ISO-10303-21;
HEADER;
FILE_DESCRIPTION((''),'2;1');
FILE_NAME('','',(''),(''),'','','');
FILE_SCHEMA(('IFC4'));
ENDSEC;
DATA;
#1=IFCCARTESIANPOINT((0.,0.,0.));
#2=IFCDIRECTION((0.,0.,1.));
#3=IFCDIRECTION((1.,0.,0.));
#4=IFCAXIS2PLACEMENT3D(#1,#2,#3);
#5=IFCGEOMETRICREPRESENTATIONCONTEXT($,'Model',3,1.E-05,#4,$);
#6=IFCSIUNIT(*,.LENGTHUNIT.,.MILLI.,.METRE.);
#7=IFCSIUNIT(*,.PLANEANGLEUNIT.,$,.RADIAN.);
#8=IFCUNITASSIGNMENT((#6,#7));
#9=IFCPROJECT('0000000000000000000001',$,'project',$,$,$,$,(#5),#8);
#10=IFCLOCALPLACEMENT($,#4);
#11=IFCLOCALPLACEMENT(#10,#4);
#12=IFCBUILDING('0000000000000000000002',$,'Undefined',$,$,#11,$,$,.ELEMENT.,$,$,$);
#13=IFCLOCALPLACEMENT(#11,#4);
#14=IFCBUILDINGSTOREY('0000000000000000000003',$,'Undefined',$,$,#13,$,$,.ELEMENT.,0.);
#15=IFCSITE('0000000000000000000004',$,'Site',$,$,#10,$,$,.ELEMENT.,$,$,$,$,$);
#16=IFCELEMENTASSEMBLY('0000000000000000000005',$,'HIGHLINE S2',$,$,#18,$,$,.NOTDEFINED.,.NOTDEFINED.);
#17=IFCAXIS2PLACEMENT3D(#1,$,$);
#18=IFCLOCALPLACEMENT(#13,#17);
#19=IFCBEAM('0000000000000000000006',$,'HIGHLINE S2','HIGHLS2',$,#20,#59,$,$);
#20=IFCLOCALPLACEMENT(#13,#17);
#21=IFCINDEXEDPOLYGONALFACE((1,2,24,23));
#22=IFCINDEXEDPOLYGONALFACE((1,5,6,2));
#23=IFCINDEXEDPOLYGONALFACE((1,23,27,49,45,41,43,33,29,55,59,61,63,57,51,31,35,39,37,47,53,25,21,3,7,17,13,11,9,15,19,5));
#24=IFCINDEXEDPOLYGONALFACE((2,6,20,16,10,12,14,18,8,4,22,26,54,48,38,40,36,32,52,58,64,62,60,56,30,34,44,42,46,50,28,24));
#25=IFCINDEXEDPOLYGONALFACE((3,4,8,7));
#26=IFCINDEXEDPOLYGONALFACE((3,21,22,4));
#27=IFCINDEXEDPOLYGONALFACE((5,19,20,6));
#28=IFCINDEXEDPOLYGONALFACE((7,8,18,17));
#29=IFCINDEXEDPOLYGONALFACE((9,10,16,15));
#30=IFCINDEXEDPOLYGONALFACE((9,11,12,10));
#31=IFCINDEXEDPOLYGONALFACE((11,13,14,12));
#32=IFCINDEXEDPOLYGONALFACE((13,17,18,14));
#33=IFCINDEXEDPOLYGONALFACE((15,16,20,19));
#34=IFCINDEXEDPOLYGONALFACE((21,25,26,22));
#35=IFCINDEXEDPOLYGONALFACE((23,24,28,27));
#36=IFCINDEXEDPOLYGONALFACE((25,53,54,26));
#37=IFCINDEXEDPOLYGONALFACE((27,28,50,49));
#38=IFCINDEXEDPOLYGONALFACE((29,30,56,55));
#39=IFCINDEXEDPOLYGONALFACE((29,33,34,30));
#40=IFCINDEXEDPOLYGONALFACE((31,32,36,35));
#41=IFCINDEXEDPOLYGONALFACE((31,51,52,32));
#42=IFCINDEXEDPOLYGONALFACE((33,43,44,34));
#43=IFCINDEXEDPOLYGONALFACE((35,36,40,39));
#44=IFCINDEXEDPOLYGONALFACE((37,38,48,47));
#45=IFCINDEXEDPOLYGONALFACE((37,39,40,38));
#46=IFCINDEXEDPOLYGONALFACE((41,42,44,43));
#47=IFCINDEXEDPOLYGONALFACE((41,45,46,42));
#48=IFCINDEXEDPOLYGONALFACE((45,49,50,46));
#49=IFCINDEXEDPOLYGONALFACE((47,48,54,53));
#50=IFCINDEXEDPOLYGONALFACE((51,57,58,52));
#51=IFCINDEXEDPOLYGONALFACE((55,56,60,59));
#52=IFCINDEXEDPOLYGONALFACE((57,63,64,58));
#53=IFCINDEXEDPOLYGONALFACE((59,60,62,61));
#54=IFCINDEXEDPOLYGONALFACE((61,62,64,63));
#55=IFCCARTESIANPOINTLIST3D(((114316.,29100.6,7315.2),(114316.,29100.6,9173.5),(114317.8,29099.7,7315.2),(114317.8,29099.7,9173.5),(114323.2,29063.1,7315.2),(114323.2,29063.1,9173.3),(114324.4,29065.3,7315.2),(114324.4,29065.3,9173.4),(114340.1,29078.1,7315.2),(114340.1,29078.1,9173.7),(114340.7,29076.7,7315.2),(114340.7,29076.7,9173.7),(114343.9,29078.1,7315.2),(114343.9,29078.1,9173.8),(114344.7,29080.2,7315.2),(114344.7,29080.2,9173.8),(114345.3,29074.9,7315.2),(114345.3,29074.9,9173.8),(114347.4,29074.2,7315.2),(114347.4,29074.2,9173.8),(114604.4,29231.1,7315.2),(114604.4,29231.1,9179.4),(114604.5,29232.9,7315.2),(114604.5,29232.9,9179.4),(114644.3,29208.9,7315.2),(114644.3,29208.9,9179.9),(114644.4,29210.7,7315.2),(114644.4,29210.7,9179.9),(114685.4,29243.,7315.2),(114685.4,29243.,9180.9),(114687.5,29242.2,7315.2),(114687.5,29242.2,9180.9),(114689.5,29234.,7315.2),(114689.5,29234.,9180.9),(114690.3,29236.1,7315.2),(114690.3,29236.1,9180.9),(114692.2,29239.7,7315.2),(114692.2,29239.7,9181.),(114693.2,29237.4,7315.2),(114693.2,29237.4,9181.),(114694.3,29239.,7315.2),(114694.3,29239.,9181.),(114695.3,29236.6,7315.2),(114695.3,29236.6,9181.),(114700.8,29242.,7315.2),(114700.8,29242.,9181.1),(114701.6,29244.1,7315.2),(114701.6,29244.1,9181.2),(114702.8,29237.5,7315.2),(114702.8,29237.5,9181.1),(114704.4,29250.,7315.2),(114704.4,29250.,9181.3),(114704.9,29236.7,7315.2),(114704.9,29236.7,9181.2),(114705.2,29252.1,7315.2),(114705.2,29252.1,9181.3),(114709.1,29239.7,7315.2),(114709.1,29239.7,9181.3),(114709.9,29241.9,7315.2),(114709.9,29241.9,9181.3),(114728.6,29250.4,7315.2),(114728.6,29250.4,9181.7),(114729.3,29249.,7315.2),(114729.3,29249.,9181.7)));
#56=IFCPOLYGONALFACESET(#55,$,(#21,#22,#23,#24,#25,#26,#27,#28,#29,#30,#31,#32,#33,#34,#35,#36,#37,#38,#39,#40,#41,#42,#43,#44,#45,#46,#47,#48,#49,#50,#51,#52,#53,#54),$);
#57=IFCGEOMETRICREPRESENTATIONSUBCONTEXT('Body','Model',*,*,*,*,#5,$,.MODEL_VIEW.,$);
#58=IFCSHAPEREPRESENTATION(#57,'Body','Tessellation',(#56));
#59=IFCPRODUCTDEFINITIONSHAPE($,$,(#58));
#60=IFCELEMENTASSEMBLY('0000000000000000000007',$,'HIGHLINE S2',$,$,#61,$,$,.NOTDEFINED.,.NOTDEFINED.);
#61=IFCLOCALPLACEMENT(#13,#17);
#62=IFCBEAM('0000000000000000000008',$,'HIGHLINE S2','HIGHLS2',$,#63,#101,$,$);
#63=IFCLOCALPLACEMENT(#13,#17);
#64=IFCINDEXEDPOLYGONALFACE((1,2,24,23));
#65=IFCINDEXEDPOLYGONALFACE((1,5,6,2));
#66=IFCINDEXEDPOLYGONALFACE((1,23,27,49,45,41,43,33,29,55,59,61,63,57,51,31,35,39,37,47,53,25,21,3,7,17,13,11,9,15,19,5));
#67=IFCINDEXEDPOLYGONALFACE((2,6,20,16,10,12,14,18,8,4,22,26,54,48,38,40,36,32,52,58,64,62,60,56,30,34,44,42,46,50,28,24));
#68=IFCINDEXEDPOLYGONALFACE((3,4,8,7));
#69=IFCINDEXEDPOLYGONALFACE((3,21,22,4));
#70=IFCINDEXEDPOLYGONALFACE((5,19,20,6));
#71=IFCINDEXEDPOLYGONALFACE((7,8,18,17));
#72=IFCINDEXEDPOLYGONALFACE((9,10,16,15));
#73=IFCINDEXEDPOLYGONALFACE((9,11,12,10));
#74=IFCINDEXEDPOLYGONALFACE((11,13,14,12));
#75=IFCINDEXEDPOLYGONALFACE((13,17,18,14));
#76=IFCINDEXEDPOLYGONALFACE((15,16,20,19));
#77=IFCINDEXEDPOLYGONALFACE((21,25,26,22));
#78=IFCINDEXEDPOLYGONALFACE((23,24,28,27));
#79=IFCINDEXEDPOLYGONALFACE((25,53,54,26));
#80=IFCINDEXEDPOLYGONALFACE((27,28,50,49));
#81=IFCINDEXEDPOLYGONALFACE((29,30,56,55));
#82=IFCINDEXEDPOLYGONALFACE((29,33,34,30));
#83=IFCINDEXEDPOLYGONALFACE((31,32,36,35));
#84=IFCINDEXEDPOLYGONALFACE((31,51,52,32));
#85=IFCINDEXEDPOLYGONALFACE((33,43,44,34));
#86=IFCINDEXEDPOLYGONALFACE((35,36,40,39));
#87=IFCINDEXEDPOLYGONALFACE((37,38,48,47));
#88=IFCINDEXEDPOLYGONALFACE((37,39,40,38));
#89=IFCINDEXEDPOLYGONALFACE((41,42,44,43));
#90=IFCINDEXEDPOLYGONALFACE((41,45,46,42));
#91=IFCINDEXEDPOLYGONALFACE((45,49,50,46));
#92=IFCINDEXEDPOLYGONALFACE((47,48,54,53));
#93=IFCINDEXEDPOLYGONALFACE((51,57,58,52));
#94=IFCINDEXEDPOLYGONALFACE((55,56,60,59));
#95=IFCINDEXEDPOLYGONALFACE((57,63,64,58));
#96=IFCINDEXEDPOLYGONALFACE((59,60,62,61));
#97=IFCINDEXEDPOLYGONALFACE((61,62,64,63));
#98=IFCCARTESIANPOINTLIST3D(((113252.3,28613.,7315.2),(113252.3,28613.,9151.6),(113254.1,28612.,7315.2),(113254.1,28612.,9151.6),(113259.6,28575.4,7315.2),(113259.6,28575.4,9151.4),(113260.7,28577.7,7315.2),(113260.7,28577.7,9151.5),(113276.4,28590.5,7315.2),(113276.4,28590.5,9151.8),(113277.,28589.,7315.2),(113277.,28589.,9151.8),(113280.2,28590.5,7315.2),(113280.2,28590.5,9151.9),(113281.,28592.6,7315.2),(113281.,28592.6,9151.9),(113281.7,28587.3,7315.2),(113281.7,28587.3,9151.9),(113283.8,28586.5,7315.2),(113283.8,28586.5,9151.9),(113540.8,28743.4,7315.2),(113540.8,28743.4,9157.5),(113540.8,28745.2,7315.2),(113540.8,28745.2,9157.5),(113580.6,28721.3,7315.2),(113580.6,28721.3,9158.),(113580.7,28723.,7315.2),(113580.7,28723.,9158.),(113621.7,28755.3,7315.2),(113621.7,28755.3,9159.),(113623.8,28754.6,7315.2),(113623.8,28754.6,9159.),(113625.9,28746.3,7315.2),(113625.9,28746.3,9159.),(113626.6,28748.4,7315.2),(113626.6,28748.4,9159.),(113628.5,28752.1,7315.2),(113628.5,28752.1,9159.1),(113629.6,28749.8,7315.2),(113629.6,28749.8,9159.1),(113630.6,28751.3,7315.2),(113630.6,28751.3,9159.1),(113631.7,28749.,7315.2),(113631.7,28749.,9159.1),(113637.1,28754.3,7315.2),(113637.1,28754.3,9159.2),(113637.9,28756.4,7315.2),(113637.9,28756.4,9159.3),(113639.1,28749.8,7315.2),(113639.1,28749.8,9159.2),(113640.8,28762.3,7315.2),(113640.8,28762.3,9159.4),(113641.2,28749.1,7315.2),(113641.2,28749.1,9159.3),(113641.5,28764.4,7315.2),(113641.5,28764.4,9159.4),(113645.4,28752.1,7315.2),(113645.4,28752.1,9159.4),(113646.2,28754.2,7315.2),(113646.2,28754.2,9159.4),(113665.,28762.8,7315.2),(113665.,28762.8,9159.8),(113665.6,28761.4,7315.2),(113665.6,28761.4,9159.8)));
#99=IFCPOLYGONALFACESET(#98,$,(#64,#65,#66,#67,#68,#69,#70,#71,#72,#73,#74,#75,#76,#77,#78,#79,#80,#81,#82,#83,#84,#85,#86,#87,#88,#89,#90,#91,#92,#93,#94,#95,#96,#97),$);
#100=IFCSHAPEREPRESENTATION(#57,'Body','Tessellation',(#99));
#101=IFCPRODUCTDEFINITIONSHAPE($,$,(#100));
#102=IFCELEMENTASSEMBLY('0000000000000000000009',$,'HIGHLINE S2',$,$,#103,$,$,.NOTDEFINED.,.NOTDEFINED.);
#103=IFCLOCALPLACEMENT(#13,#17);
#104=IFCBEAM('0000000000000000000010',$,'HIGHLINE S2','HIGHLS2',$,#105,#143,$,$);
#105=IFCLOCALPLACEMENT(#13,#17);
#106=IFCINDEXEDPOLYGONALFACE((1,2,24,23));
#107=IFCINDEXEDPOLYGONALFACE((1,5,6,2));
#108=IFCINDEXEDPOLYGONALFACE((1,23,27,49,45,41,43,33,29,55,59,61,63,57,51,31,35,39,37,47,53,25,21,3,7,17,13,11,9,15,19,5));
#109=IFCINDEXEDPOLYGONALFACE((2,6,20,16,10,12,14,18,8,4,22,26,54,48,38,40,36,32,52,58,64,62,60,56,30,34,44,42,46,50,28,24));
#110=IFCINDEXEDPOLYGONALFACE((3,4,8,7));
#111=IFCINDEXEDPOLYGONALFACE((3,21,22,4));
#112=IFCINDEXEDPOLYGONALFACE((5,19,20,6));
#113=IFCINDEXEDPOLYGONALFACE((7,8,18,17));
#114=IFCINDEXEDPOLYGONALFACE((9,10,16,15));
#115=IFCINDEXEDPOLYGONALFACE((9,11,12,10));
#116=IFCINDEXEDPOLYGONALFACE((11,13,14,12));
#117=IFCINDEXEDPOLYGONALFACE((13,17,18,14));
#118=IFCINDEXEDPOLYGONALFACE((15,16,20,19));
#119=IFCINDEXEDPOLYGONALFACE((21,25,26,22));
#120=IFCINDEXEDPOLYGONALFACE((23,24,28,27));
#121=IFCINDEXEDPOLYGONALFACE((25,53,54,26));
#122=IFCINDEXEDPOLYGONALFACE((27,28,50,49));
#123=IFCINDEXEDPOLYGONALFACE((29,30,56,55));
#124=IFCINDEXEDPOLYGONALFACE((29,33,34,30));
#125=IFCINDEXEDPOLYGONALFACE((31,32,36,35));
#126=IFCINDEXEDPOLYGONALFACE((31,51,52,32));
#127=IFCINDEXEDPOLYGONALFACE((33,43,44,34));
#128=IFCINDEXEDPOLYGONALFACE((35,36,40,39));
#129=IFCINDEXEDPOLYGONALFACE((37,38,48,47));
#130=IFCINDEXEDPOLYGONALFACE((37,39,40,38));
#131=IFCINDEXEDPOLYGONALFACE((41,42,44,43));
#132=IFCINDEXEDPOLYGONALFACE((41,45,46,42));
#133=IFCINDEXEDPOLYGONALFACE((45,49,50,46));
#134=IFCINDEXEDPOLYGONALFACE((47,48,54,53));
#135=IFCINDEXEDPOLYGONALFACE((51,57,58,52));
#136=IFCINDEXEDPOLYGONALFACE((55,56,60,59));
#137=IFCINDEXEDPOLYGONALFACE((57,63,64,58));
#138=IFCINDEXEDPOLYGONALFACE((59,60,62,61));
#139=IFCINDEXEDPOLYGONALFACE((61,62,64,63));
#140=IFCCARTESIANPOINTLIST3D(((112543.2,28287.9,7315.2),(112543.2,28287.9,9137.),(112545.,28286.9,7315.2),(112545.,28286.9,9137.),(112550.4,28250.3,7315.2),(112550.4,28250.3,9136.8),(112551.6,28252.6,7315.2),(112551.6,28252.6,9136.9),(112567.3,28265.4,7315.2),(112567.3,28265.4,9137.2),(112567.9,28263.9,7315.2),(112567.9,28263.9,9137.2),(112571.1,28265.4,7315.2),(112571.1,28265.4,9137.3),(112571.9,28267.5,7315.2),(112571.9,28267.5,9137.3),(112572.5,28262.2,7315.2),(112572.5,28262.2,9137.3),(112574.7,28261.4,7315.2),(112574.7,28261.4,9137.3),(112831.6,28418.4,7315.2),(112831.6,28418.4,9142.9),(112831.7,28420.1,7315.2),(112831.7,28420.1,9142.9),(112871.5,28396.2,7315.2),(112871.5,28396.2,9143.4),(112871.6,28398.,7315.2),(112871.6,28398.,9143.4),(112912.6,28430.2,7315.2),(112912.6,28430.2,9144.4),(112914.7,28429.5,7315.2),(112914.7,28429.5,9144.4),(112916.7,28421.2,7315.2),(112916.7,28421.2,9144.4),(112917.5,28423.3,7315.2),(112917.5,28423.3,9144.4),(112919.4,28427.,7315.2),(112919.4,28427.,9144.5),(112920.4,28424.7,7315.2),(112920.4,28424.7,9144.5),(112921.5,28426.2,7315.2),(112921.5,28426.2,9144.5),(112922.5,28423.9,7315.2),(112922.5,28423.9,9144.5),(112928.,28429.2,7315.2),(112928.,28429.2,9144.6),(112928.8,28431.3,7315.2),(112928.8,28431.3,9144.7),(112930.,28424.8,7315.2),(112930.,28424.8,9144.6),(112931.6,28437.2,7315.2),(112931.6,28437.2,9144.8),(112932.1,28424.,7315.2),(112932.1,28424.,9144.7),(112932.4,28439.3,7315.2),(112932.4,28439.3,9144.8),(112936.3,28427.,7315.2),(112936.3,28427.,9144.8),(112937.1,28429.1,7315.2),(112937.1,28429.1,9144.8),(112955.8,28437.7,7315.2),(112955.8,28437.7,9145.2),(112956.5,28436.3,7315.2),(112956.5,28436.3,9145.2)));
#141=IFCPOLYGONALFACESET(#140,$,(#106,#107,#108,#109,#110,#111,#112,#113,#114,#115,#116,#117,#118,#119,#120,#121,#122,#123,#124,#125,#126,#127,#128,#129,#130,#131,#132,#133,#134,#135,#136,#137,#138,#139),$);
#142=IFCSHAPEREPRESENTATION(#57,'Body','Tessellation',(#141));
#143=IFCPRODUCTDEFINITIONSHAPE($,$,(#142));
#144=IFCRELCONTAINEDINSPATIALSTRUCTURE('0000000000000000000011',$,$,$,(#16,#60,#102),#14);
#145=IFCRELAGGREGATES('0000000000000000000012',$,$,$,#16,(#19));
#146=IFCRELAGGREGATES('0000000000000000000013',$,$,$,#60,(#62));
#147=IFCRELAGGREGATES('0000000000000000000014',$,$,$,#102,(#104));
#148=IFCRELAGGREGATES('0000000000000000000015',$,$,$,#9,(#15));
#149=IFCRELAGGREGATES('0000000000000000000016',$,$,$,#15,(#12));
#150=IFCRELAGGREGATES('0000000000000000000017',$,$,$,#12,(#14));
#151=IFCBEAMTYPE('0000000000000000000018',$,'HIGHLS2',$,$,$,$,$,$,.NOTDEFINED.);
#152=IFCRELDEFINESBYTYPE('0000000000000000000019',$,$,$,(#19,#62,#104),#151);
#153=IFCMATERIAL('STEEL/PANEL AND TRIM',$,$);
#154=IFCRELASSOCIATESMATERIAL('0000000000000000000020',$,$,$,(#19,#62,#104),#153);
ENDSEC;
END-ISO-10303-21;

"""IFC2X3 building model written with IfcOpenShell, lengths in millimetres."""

from ifc_helpers import new_model, si_unit, frame, origin_with_axes, place, context, subcontext, project, spatial, polyline, outline, extrude, boolean, halfspace, material, type_object, element, aggregate, save


model = new_model("IFC2X3")

# Units and contexts
model_context = context("Model", 3, precision=1e-05, world=origin_with_axes())
body_context = subcontext(model_context, "Body", "Model", "MODEL_VIEW")
ifc_project = project(units=[si_unit("LENGTHUNIT", "METRE", prefix="MILLI"), si_unit("PLANEANGLEUNIT", "RADIAN")], contexts=[model_context])

# Site, building, storey
site_placement = place(None, origin_with_axes())
site = spatial("IfcSite", under=ifc_project, at=site_placement, Name="Site", CompositionType="ELEMENT")
building_placement = place(site_placement, origin_with_axes())
building = spatial("IfcBuilding", under=site, at=building_placement, Name="Undefined", CompositionType="ELEMENT")
storey_placement = place(building_placement, origin_with_axes())
storey = spatial("IfcBuildingStorey", under=building, at=storey_placement, Name="Undefined", CompositionType="ELEMENT", Elevation=0.0)

# Element assemblies, beams
ifc_material_1 = material(Name="STEEL/PANEL AND TRIM")
beam_type_1 = type_object("IfcBeamType", Name="HIGHLS2", PredefinedType="NOTDEFINED")
assembly_1_placement = place(storey_placement, origin_with_axes())
assembly_1 = element("IfcElementAssembly", 1, at=assembly_1_placement, inside=storey, Name="HIGHLINE S2", AssemblyPlace="NOTDEFINED", PredefinedType="NOTDEFINED")
beam_1_placement = place(assembly_1_placement, frame((114316.0, 29100.6, 4267.2), z_axis=(0.41674, -0.909026, 0.0), x_axis=(0.0, 0.0, 1.0)))
beam_1 = element("IfcBeam", 2, at=beam_1_placement, type_object=beam_type_1, material=ifc_material_1, Name="HIGHLINE S2", Description="HIGHLS2", context=body_context, shape_type="CSG", body=[
    boolean("DIFFERENCE", boolean("DIFFERENCE", extrude(outline(polyline([(415.4, 26.1), (415.4, 37.3), (437.6, 37.3), (437.6, 35.7), (417.0, 35.7), (417.0, 24.5), (395.1, 24.5), (395.1, 34.4), (401.5, 34.4), (401.5, 31.9), (408.7, 31.9), (408.7, 36.8), (344.4, 36.8), (317.4, 0.0), (0.0, 0.0), (-9.0, 37.1), (17.6, 37.1), (17.6, 30.5), (12.5, 30.5), (12.5, 32.1), (16.0, 32.1), (16.0, 35.5), (-7.0, 35.5), (1.2, 1.6), (316.6, 1.6), (343.6, 38.4), (410.3, 38.4), (410.3, 30.3), (400.0, 30.3), (400.0, 32.8), (396.7, 32.8), (396.7, 26.1), (415.4, 26.1)])), frame((10000.0, 0.0, 0.0), z_axis=(-1.0, 0.0, 0.0), x_axis=(0.0, -1.0, 0.0)), (0.0, 0.0, 1.0), 10000.0), extrude(outline(polyline([(0.0, 0.0), (6400.8, 0.0), (6400.8, 3048.0), (0.0, 3048.0), (0.0, 0.0)])), frame((0.0, 3436.4, -9.8), z_axis=(0.0, 0.0, 1.0), x_axis=(0.0, -1.0, 0.0)), (0.0, 0.0, 1.0), 58.0)), halfspace(frame((4896.9, 500.0, 500.0), z_axis=(0.999825, 0.018709, 0.0), x_axis=(0.0, 0.0, -1.0)), False)),
])
aggregate(assembly_1, [beam_1])
assembly_2_placement = place(storey_placement, origin_with_axes())
assembly_2 = element("IfcElementAssembly", 3, at=assembly_2_placement, inside=storey, Name="HIGHLINE S2", AssemblyPlace="NOTDEFINED", PredefinedType="NOTDEFINED")
beam_2_placement = place(assembly_2_placement, frame((113252.3, 28613.0, 4267.2), z_axis=(0.41674, -0.909026, 0.0), x_axis=(0.0, 0.0, 1.0)))
beam_2 = element("IfcBeam", 4, at=beam_2_placement, type_object=beam_type_1, material=ifc_material_1, Name="HIGHLINE S2", Description="HIGHLS2", context=body_context, shape_type="CSG", body=[
    boolean("DIFFERENCE", boolean("DIFFERENCE", extrude(outline(polyline([(415.4, 26.1), (415.4, 37.3), (437.6, 37.3), (437.6, 35.7), (417.0, 35.7), (417.0, 24.5), (395.1, 24.5), (395.1, 34.4), (401.5, 34.4), (401.5, 31.9), (408.7, 31.9), (408.7, 36.8), (344.4, 36.8), (317.4, 0.0), (0.0, 0.0), (-9.0, 37.1), (17.6, 37.1), (17.6, 30.5), (12.5, 30.5), (12.5, 32.1), (16.0, 32.1), (16.0, 35.5), (-7.0, 35.5), (1.2, 1.6), (316.6, 1.6), (343.6, 38.4), (410.3, 38.4), (410.3, 30.3), (400.0, 30.3), (400.0, 32.8), (396.7, 32.8), (396.7, 26.1), (415.4, 26.1)])), frame((10000.0, 0.0, 0.0), z_axis=(-1.0, 0.0, 0.0), x_axis=(0.0, -1.0, 0.0)), (0.0, 0.0, 1.0), 10000.0), extrude(outline(polyline([(0.0, 0.0), (6400.8, 0.0), (6400.8, 3048.0), (0.0, 3048.0), (0.0, 0.0)])), frame((0.0, 2266.3, -9.8), z_axis=(0.0, 0.0, 1.0), x_axis=(0.0, -1.0, 0.0)), (0.0, 0.0, 1.0), 58.0)), halfspace(frame((4875.0, 500.0, 500.0), z_axis=(0.999825, 0.018709, 0.0), x_axis=(0.0, 0.0, -1.0)), False)),
])
aggregate(assembly_2, [beam_2])
assembly_3_placement = place(storey_placement, origin_with_axes())
assembly_3 = element("IfcElementAssembly", 5, at=assembly_3_placement, inside=storey, Name="HIGHLINE S2", AssemblyPlace="NOTDEFINED", PredefinedType="NOTDEFINED")
beam_3_placement = place(assembly_3_placement, frame((112543.2, 28287.9, 4267.2), z_axis=(0.41674, -0.909026, 0.0), x_axis=(0.0, 0.0, 1.0)))
beam_3 = element("IfcBeam", 6, at=beam_3_placement, type_object=beam_type_1, material=ifc_material_1, Name="HIGHLINE S2", Description="HIGHLS2", context=body_context, shape_type="CSG", body=[
    boolean("DIFFERENCE", boolean("DIFFERENCE", extrude(outline(polyline([(415.4, 26.1), (415.4, 37.3), (437.6, 37.3), (437.6, 35.7), (417.0, 35.7), (417.0, 24.5), (395.1, 24.5), (395.1, 34.4), (401.5, 34.4), (401.5, 31.9), (408.7, 31.9), (408.7, 36.8), (344.4, 36.8), (317.4, 0.0), (0.0, 0.0), (-9.0, 37.1), (17.6, 37.1), (17.6, 30.5), (12.5, 30.5), (12.5, 32.1), (16.0, 32.1), (16.0, 35.5), (-7.0, 35.5), (1.2, 1.6), (316.6, 1.6), (343.6, 38.4), (410.3, 38.4), (410.3, 30.3), (400.0, 30.3), (400.0, 32.8), (396.7, 32.8), (396.7, 26.1), (415.4, 26.1)])), frame((10000.0, 0.0, 0.0), z_axis=(-1.0, 0.0, 0.0), x_axis=(0.0, -1.0, 0.0)), (0.0, 0.0, 1.0), 10000.0), extrude(outline(polyline([(0.0, 0.0), (6400.8, 0.0), (6400.8, 3048.0), (0.0, 3048.0), (0.0, 0.0)])), frame((0.0, 1486.2, -9.8), z_axis=(0.0, 0.0, 1.0), x_axis=(0.0, -1.0, 0.0)), (0.0, 0.0, 1.0), 58.0)), halfspace(frame((4860.4, 500.0, 500.0), z_axis=(0.999825, 0.018709, 0.0), x_axis=(0.0, 0.0, -1.0)), False)),
])
aggregate(assembly_3, [beam_3])

save(model, "model.ifc")
